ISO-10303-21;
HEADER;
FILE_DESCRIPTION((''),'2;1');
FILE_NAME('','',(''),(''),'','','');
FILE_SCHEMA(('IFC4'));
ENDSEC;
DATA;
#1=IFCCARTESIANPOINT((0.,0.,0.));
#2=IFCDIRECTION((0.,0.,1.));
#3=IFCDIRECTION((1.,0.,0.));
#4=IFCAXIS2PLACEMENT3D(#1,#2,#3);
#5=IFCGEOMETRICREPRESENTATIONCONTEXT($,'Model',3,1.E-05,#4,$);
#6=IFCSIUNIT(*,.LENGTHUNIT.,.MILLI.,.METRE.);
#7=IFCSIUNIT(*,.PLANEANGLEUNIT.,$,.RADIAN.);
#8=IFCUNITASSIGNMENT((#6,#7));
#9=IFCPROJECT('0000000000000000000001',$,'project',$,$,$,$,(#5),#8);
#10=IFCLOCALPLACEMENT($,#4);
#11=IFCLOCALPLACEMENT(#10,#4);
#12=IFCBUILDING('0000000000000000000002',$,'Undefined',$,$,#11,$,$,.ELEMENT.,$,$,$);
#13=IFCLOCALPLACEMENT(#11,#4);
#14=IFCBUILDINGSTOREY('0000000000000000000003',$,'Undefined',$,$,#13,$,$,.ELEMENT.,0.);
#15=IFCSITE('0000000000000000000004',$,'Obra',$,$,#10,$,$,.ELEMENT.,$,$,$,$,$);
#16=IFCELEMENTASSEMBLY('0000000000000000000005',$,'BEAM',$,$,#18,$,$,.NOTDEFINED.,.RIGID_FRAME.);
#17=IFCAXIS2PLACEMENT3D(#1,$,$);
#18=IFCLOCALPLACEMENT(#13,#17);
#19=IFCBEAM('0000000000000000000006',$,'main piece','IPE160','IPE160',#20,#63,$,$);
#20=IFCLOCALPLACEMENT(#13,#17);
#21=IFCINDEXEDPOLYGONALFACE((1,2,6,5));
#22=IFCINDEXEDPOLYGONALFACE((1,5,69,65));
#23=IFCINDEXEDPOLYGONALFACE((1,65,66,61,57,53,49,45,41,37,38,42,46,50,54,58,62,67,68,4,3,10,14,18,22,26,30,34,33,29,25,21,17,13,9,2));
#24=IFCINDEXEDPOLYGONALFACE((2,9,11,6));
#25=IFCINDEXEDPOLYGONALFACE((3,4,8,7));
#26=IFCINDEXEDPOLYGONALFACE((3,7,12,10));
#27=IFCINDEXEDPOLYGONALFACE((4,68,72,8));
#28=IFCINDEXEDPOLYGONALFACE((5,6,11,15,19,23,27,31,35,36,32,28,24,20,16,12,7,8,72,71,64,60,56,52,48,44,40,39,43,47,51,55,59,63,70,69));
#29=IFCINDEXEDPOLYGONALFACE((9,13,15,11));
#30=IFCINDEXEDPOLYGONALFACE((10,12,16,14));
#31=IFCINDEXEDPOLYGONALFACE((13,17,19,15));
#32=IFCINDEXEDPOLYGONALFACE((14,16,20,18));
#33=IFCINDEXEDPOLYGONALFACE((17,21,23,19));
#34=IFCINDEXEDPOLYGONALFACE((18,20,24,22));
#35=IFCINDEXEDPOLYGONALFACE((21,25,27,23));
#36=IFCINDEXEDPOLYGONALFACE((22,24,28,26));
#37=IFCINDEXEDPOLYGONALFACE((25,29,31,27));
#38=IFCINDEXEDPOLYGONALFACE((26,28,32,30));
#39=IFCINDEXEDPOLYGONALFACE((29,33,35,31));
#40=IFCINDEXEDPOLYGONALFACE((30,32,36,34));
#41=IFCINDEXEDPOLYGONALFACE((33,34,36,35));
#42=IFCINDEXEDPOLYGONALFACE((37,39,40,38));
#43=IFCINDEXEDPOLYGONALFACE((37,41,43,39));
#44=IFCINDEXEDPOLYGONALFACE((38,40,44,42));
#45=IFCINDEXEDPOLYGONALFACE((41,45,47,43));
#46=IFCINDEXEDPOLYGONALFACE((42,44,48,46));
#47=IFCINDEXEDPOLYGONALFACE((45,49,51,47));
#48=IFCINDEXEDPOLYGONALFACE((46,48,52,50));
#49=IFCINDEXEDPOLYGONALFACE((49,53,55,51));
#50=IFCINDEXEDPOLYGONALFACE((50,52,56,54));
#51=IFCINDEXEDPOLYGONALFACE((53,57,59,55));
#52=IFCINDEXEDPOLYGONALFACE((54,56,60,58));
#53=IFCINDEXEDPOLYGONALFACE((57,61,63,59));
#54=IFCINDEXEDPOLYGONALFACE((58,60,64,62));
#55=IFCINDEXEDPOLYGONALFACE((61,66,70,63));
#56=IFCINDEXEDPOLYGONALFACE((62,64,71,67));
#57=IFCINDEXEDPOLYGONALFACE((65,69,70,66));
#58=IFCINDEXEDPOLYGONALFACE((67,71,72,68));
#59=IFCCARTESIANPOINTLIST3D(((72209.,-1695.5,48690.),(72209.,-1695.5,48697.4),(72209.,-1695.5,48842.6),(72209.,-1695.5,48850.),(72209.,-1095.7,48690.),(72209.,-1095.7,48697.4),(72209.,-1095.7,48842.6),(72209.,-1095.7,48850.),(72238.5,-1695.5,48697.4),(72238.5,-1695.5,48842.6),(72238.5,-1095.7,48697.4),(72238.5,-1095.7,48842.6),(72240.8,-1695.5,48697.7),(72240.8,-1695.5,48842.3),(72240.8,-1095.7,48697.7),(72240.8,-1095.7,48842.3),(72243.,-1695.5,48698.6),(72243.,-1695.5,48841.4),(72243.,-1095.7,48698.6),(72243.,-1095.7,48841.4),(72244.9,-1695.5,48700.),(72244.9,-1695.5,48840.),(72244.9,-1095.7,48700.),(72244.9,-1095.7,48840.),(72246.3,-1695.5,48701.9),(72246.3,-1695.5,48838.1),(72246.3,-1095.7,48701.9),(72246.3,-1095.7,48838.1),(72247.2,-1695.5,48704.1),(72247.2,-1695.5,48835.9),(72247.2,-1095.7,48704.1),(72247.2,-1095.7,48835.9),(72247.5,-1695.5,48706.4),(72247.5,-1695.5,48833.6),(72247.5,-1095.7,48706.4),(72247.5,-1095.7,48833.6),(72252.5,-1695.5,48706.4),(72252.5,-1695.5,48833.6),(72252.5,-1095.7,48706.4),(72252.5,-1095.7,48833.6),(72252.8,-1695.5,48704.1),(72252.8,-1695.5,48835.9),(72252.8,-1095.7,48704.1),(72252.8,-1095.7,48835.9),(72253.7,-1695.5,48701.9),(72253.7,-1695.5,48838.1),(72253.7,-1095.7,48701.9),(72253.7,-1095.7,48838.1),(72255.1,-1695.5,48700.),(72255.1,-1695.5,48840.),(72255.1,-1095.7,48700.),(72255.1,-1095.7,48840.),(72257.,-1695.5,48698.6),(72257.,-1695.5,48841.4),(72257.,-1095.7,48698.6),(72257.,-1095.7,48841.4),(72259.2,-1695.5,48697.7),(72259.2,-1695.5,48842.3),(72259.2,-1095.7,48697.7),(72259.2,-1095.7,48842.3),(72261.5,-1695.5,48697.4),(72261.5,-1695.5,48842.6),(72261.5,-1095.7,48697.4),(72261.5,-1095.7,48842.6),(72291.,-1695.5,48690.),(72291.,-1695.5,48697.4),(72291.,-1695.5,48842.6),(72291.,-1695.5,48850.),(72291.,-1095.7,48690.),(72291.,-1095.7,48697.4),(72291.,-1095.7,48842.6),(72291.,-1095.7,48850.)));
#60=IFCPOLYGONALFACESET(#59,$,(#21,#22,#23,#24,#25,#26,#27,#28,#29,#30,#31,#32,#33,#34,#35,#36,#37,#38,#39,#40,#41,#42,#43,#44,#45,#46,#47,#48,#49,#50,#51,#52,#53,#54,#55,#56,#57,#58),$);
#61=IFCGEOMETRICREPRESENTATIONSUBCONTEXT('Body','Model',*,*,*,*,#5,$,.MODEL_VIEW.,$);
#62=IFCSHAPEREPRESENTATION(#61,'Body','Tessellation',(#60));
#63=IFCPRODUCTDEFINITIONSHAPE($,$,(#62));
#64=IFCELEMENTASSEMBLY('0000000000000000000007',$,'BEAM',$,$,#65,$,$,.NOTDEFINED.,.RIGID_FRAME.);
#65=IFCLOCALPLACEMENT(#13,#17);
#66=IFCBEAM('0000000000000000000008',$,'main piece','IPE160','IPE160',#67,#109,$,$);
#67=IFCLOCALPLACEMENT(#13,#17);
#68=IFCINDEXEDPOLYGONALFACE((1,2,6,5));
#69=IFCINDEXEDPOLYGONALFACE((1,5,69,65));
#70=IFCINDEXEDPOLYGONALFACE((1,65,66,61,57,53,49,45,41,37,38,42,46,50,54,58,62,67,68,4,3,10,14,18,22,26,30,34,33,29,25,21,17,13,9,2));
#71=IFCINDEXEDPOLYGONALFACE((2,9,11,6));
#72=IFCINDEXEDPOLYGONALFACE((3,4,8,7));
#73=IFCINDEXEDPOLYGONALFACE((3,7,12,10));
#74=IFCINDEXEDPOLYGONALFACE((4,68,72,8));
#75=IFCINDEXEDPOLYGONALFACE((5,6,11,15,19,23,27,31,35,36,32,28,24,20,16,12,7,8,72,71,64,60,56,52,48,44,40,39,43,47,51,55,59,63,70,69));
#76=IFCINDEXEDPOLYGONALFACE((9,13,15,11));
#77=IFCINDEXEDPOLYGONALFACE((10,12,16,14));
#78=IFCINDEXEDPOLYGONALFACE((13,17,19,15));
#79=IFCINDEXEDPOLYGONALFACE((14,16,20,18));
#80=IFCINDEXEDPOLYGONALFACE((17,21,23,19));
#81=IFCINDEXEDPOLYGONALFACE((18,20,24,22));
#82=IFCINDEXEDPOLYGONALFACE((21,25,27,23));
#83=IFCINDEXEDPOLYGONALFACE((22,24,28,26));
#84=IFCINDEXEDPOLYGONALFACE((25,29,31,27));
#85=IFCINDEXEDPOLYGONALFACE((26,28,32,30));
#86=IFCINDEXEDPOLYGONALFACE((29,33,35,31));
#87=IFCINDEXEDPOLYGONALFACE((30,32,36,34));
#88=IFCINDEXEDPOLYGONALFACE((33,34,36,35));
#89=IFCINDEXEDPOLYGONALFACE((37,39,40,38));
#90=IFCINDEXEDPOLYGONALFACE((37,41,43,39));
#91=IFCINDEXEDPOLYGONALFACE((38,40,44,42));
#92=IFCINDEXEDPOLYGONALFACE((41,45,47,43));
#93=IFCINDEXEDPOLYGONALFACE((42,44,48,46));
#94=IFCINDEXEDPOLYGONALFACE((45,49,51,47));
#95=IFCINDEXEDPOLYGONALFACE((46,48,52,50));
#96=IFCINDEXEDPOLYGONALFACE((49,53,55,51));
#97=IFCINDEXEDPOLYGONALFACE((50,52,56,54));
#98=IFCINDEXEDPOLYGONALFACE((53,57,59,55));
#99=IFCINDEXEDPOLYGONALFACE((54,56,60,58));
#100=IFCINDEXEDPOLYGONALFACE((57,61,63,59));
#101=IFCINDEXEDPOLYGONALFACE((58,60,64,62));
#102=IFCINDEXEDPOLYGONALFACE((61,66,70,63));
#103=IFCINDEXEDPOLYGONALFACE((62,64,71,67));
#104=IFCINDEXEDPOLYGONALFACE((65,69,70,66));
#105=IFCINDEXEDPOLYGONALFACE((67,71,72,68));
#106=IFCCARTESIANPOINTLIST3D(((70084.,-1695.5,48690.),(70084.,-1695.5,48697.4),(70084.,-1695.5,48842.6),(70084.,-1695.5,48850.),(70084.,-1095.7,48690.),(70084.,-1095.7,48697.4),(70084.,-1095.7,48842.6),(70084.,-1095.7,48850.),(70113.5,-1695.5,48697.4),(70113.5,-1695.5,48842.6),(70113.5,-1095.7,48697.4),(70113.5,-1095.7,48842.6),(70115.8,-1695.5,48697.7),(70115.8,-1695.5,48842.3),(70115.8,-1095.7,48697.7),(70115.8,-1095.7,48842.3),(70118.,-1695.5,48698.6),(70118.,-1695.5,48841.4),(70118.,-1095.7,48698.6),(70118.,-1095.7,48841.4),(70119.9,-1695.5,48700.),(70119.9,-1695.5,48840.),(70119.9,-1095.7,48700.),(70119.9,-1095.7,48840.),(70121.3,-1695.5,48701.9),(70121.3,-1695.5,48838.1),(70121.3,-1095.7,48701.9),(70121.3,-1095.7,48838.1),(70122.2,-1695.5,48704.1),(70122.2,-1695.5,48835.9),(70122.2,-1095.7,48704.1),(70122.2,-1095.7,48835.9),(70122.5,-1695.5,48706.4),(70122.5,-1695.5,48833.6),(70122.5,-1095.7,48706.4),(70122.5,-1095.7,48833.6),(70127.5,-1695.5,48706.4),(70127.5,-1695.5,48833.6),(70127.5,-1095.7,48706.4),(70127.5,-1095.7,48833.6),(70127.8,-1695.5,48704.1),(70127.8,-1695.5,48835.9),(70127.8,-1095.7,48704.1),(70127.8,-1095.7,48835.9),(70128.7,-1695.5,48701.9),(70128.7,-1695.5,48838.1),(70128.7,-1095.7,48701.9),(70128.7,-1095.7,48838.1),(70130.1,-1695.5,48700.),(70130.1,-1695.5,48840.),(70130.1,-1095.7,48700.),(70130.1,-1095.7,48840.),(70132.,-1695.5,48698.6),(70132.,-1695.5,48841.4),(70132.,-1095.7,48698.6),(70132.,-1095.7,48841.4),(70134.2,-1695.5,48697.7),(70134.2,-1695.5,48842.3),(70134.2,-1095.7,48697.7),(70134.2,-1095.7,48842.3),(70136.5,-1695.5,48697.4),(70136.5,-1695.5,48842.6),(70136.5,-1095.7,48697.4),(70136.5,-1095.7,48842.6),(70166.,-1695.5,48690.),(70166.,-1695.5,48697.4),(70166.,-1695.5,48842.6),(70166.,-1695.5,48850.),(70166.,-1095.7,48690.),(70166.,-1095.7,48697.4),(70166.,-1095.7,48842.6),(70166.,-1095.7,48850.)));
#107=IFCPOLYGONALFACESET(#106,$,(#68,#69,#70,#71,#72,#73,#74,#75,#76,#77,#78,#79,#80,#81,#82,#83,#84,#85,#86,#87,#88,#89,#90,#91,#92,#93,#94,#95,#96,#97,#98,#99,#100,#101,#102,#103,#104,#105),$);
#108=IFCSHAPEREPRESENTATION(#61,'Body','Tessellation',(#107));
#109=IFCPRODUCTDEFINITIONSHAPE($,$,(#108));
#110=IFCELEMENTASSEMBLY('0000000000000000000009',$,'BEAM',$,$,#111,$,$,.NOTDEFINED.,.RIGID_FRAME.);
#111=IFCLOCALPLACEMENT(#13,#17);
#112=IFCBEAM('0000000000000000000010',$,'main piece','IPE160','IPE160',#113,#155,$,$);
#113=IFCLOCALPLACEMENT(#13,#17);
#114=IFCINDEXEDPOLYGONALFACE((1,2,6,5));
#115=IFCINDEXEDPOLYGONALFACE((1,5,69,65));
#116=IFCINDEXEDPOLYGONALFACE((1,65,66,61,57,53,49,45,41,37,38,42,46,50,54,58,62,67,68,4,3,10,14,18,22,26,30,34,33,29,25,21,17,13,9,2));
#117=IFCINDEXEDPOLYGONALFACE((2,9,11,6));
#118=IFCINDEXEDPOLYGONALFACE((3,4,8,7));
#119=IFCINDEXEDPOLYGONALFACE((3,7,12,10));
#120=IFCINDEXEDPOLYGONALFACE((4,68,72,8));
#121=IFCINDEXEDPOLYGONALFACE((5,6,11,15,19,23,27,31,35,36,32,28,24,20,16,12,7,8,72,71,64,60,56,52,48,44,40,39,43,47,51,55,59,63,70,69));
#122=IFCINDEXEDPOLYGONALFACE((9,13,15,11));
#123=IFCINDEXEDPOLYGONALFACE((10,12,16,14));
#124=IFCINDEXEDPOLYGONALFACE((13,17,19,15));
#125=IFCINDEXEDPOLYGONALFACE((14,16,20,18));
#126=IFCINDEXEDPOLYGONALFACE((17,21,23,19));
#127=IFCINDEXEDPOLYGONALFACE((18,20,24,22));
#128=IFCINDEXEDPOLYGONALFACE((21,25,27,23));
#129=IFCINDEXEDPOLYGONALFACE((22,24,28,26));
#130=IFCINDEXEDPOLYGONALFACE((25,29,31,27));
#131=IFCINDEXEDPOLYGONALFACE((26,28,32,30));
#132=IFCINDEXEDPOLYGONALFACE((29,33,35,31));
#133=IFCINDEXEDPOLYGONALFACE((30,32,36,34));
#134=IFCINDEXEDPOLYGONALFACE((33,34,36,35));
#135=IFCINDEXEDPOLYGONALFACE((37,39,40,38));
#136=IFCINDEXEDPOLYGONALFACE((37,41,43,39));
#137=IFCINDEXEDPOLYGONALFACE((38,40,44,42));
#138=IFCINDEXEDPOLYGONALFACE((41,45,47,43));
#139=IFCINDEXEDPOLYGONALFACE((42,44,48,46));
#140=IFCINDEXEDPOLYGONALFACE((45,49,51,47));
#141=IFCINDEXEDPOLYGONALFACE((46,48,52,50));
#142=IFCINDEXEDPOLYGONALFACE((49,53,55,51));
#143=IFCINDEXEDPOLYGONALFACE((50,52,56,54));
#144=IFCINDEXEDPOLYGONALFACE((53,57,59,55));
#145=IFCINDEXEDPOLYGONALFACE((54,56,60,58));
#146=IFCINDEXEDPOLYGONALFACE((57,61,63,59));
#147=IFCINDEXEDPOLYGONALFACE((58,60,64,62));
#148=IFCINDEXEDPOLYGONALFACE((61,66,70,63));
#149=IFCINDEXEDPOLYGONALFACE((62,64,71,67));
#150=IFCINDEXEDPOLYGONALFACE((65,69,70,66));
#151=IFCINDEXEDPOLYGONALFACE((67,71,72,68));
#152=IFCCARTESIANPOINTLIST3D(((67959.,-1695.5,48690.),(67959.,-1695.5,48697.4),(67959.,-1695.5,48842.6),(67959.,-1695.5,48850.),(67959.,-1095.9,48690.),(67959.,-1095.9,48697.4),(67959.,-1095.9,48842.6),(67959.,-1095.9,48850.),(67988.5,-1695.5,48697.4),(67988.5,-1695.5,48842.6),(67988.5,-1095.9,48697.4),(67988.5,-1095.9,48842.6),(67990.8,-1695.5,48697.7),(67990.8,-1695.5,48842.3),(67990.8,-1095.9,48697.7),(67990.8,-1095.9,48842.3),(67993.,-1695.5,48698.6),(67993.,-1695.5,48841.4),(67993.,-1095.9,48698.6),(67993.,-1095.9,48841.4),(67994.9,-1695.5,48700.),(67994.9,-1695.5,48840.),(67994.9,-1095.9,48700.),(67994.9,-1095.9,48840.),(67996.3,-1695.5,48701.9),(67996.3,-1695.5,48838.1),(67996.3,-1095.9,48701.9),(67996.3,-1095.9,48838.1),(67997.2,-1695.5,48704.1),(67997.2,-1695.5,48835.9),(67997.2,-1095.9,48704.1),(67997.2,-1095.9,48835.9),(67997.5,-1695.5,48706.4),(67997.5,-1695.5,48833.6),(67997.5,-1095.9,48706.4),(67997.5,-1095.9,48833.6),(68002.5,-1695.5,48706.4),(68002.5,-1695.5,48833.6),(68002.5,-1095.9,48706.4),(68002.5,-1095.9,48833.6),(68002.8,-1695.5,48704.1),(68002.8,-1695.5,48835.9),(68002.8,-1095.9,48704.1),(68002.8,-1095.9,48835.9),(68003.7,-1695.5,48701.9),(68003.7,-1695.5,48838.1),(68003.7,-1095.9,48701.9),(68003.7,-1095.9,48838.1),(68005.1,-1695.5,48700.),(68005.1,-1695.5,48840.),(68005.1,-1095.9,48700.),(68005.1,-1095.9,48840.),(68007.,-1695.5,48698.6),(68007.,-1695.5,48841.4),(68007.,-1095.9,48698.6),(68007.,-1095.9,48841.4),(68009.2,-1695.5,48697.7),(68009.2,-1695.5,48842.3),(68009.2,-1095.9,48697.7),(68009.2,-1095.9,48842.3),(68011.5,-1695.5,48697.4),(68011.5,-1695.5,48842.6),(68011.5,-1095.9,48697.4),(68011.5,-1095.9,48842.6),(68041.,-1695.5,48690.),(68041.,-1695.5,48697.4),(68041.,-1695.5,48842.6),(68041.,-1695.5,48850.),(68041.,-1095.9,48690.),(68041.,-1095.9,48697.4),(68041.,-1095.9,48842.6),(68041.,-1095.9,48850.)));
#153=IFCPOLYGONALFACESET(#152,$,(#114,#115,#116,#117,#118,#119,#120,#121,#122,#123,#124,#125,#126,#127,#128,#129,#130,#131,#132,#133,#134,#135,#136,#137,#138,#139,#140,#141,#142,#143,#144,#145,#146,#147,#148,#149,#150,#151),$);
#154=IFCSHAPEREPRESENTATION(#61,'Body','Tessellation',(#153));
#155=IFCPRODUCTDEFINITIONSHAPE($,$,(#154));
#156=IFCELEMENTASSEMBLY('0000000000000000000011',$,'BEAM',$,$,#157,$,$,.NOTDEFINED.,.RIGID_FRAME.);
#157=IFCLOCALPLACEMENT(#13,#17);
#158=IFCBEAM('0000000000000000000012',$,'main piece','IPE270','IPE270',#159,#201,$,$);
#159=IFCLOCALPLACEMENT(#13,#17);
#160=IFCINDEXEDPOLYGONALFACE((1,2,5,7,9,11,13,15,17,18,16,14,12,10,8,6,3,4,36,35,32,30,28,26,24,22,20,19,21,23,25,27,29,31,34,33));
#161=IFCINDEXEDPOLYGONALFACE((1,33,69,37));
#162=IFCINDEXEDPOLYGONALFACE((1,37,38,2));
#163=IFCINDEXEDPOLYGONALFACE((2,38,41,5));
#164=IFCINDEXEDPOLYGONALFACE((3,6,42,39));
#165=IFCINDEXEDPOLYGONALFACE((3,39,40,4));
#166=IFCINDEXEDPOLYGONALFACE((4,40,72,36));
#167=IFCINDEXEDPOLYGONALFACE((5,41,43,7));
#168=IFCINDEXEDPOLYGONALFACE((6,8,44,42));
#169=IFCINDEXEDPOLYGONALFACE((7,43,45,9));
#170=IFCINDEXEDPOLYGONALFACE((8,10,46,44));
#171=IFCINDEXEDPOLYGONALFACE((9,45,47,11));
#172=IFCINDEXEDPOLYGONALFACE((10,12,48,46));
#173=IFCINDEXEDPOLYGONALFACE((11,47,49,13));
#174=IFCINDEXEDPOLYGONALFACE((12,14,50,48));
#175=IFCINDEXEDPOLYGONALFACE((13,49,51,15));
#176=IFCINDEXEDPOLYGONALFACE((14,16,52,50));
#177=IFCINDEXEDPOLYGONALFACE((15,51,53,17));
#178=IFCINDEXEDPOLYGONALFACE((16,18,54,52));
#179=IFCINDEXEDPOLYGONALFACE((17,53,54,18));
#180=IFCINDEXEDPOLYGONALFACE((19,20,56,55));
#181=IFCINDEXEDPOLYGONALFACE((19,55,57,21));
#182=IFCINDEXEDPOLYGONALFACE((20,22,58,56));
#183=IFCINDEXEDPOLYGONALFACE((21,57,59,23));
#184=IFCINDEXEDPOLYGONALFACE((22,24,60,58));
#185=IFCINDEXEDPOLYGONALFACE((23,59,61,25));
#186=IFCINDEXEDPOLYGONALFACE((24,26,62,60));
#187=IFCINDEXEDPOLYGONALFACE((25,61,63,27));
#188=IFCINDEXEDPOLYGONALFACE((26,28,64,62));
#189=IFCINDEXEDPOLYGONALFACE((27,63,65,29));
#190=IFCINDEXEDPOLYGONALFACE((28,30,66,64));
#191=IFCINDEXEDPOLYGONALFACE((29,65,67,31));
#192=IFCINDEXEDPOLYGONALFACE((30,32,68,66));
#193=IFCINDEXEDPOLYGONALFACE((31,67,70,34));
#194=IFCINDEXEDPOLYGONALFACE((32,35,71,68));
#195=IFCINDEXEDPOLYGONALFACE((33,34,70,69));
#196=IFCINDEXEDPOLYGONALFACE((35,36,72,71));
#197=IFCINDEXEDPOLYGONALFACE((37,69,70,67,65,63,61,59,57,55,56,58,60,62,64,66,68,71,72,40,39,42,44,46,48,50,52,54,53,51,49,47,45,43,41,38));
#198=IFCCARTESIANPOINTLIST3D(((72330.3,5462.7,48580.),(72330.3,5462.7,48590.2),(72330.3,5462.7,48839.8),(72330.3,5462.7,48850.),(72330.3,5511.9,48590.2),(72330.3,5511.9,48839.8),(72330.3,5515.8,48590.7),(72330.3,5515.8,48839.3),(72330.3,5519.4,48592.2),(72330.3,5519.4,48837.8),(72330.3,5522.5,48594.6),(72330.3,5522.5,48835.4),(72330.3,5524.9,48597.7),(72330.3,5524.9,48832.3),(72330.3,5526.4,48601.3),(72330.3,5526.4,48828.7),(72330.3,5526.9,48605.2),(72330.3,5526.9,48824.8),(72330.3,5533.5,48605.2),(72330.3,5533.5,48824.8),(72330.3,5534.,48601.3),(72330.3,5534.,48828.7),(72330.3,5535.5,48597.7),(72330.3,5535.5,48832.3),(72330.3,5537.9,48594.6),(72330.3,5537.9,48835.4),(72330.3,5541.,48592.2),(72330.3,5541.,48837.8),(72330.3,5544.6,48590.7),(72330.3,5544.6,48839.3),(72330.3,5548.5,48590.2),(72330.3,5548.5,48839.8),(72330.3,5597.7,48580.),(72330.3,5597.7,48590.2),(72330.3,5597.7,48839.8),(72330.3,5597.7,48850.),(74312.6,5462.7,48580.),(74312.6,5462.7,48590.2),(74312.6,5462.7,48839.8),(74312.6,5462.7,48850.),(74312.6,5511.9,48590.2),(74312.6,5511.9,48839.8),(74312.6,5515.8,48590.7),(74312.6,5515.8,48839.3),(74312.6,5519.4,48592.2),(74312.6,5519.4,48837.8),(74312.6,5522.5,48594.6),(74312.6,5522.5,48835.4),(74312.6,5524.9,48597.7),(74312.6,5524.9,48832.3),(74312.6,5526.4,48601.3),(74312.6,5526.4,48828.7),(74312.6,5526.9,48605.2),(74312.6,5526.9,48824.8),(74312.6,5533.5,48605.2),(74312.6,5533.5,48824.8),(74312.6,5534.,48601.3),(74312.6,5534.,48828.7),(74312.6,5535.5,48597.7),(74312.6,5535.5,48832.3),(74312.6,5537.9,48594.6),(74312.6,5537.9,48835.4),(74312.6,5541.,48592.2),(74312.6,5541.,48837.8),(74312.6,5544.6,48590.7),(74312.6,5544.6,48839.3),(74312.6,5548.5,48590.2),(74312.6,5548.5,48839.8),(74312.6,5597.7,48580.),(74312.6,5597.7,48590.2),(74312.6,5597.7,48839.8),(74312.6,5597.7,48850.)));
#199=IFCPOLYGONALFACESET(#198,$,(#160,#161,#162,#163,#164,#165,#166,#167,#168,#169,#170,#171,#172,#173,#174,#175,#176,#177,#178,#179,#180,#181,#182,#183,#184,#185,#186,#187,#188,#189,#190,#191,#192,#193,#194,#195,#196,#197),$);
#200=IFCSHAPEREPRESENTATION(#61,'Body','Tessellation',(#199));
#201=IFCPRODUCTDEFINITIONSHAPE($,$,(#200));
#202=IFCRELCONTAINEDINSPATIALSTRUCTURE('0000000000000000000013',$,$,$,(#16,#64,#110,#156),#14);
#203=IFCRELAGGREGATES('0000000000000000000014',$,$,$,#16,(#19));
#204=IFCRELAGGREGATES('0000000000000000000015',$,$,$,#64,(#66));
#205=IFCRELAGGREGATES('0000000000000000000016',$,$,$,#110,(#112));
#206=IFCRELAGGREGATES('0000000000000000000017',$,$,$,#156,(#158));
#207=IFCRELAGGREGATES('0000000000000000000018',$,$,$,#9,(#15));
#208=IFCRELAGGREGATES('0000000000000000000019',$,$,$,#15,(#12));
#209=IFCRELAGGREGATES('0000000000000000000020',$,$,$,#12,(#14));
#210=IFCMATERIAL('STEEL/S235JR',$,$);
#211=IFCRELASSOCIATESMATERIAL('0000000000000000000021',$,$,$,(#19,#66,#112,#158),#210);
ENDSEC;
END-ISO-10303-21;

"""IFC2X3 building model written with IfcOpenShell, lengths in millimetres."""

from ifc_helpers import new_model, si_unit, frame, origin_with_axes, origin_2d_with_axis, place, context, subcontext, project, spatial, i_section, extrude, material, element, aggregate, save


model = new_model("IFC2X3")

# Units and contexts
model_context = context("Model", 3, precision=1e-05, world=origin_with_axes())
body_context = subcontext(model_context, "Body", "Model", "MODEL_VIEW")
ifc_project = project(units=[si_unit("LENGTHUNIT", "METRE", prefix="MILLI"), si_unit("PLANEANGLEUNIT", "RADIAN")], contexts=[model_context])

# Site, building, storey
site_placement = place(None, origin_with_axes())
site = spatial("IfcSite", under=ifc_project, at=site_placement, Name="Obra", CompositionType="ELEMENT")
building_placement = place(site_placement, origin_with_axes())
building = spatial("IfcBuilding", under=site, at=building_placement, Name="Undefined", CompositionType="ELEMENT")
storey_placement = place(building_placement, origin_with_axes())
storey = spatial("IfcBuildingStorey", under=building, at=storey_placement, Name="Undefined", CompositionType="ELEMENT", Elevation=0.0)

# Shared definitions
ifc_material_1 = material(Name="STEEL/S235JR")

# Element assemblies, beams
assembly_1_placement = place(storey_placement, origin_with_axes())
assembly_1 = element("IfcElementAssembly", 1, at=assembly_1_placement, inside=storey, Name="BEAM", AssemblyPlace="NOTDEFINED", PredefinedType="RIGID_FRAME")
beam_1_placement = place(assembly_1_placement, frame((72250.0, -1095.7, 48770.0), z_axis=(0.0, 0.0, 1.0), x_axis=(0.0, -1.0, 0.0)))
beam_1 = element("IfcBeam", 2, at=beam_1_placement, material=ifc_material_1, Name="main piece", Description="IPE160", ObjectType="IPE160", context=body_context, shape_type="SweptSolid", body=[
    extrude(i_section(OverallWidth=82.0, OverallDepth=160.0, WebThickness=5.0, FlangeThickness=7.4, FilletRadius=9.0, at=origin_2d_with_axis()), frame((599.8, 0.0, 0.0), z_axis=(-1.0, 0.0, 0.0), x_axis=(0.0, -1.0, 0.0)), (0.0, 0.0, 1.0), 599.8),
])
aggregate(assembly_1, [beam_1])
assembly_2_placement = place(storey_placement, origin_with_axes())
assembly_2 = element("IfcElementAssembly", 3, at=assembly_2_placement, inside=storey, Name="BEAM", AssemblyPlace="NOTDEFINED", PredefinedType="RIGID_FRAME")
beam_2_placement = place(assembly_2_placement, frame((70125.0, -1695.5, 48770.0), z_axis=(0.0, 0.0, 1.0), x_axis=(0.0, 1.0, 0.0)))
beam_2 = element("IfcBeam", 4, at=beam_2_placement, material=ifc_material_1, Name="main piece", Description="IPE160", ObjectType="IPE160", context=body_context, shape_type="SweptSolid", body=[
    extrude(i_section(OverallWidth=82.0, OverallDepth=160.0, WebThickness=5.0, FlangeThickness=7.4, FilletRadius=9.0, at=origin_2d_with_axis()), frame((599.8, 0.0, 0.0), z_axis=(-1.0, 0.0, 0.0), x_axis=(0.0, -1.0, 0.0)), (0.0, 0.0, 1.0), 599.8),
])
aggregate(assembly_2, [beam_2])
assembly_3_placement = place(storey_placement, origin_with_axes())
assembly_3 = element("IfcElementAssembly", 5, at=assembly_3_placement, inside=storey, Name="BEAM", AssemblyPlace="NOTDEFINED", PredefinedType="RIGID_FRAME")
beam_3_placement = place(assembly_3_placement, frame((68000.0, -1095.9, 48770.0), z_axis=(0.0, 0.0, 1.0), x_axis=(0.0, -1.0, 0.0)))
beam_3 = element("IfcBeam", 6, at=beam_3_placement, material=ifc_material_1, Name="main piece", Description="IPE160", ObjectType="IPE160", context=body_context, shape_type="SweptSolid", body=[
    extrude(i_section(OverallWidth=82.0, OverallDepth=160.0, WebThickness=5.0, FlangeThickness=7.4, FilletRadius=9.0, at=origin_2d_with_axis()), frame((599.6, 0.0, 0.0), z_axis=(-1.0, 0.0, 0.0), x_axis=(0.0, -1.0, 0.0)), (0.0, 0.0, 1.0), 599.6),
])
aggregate(assembly_3, [beam_3])
assembly_4_placement = place(storey_placement, origin_with_axes())
assembly_4 = element("IfcElementAssembly", 7, at=assembly_4_placement, inside=storey, Name="BEAM", AssemblyPlace="NOTDEFINED", PredefinedType="RIGID_FRAME")
beam_4_placement = place(assembly_4_placement, frame((72330.3, 5530.2, 48715.0), z_axis=(0.0, 0.0, 1.0), x_axis=(1.0, 0.0, 0.0)))
beam_4 = element("IfcBeam", 8, at=beam_4_placement, material=ifc_material_1, Name="main piece", Description="IPE270", ObjectType="IPE270", context=body_context, shape_type="SweptSolid", body=[
    extrude(i_section(OverallWidth=135.0, OverallDepth=270.0, WebThickness=6.6, FlangeThickness=10.2, FilletRadius=15.0, at=origin_2d_with_axis()), frame((1982.3, 0.0, 0.0), z_axis=(-1.0, 0.0, 0.0), x_axis=(0.0, -1.0, 0.0)), (0.0, 0.0, 1.0), 1982.3),
])
aggregate(assembly_4, [beam_4])

save(model, "model.ifc")
